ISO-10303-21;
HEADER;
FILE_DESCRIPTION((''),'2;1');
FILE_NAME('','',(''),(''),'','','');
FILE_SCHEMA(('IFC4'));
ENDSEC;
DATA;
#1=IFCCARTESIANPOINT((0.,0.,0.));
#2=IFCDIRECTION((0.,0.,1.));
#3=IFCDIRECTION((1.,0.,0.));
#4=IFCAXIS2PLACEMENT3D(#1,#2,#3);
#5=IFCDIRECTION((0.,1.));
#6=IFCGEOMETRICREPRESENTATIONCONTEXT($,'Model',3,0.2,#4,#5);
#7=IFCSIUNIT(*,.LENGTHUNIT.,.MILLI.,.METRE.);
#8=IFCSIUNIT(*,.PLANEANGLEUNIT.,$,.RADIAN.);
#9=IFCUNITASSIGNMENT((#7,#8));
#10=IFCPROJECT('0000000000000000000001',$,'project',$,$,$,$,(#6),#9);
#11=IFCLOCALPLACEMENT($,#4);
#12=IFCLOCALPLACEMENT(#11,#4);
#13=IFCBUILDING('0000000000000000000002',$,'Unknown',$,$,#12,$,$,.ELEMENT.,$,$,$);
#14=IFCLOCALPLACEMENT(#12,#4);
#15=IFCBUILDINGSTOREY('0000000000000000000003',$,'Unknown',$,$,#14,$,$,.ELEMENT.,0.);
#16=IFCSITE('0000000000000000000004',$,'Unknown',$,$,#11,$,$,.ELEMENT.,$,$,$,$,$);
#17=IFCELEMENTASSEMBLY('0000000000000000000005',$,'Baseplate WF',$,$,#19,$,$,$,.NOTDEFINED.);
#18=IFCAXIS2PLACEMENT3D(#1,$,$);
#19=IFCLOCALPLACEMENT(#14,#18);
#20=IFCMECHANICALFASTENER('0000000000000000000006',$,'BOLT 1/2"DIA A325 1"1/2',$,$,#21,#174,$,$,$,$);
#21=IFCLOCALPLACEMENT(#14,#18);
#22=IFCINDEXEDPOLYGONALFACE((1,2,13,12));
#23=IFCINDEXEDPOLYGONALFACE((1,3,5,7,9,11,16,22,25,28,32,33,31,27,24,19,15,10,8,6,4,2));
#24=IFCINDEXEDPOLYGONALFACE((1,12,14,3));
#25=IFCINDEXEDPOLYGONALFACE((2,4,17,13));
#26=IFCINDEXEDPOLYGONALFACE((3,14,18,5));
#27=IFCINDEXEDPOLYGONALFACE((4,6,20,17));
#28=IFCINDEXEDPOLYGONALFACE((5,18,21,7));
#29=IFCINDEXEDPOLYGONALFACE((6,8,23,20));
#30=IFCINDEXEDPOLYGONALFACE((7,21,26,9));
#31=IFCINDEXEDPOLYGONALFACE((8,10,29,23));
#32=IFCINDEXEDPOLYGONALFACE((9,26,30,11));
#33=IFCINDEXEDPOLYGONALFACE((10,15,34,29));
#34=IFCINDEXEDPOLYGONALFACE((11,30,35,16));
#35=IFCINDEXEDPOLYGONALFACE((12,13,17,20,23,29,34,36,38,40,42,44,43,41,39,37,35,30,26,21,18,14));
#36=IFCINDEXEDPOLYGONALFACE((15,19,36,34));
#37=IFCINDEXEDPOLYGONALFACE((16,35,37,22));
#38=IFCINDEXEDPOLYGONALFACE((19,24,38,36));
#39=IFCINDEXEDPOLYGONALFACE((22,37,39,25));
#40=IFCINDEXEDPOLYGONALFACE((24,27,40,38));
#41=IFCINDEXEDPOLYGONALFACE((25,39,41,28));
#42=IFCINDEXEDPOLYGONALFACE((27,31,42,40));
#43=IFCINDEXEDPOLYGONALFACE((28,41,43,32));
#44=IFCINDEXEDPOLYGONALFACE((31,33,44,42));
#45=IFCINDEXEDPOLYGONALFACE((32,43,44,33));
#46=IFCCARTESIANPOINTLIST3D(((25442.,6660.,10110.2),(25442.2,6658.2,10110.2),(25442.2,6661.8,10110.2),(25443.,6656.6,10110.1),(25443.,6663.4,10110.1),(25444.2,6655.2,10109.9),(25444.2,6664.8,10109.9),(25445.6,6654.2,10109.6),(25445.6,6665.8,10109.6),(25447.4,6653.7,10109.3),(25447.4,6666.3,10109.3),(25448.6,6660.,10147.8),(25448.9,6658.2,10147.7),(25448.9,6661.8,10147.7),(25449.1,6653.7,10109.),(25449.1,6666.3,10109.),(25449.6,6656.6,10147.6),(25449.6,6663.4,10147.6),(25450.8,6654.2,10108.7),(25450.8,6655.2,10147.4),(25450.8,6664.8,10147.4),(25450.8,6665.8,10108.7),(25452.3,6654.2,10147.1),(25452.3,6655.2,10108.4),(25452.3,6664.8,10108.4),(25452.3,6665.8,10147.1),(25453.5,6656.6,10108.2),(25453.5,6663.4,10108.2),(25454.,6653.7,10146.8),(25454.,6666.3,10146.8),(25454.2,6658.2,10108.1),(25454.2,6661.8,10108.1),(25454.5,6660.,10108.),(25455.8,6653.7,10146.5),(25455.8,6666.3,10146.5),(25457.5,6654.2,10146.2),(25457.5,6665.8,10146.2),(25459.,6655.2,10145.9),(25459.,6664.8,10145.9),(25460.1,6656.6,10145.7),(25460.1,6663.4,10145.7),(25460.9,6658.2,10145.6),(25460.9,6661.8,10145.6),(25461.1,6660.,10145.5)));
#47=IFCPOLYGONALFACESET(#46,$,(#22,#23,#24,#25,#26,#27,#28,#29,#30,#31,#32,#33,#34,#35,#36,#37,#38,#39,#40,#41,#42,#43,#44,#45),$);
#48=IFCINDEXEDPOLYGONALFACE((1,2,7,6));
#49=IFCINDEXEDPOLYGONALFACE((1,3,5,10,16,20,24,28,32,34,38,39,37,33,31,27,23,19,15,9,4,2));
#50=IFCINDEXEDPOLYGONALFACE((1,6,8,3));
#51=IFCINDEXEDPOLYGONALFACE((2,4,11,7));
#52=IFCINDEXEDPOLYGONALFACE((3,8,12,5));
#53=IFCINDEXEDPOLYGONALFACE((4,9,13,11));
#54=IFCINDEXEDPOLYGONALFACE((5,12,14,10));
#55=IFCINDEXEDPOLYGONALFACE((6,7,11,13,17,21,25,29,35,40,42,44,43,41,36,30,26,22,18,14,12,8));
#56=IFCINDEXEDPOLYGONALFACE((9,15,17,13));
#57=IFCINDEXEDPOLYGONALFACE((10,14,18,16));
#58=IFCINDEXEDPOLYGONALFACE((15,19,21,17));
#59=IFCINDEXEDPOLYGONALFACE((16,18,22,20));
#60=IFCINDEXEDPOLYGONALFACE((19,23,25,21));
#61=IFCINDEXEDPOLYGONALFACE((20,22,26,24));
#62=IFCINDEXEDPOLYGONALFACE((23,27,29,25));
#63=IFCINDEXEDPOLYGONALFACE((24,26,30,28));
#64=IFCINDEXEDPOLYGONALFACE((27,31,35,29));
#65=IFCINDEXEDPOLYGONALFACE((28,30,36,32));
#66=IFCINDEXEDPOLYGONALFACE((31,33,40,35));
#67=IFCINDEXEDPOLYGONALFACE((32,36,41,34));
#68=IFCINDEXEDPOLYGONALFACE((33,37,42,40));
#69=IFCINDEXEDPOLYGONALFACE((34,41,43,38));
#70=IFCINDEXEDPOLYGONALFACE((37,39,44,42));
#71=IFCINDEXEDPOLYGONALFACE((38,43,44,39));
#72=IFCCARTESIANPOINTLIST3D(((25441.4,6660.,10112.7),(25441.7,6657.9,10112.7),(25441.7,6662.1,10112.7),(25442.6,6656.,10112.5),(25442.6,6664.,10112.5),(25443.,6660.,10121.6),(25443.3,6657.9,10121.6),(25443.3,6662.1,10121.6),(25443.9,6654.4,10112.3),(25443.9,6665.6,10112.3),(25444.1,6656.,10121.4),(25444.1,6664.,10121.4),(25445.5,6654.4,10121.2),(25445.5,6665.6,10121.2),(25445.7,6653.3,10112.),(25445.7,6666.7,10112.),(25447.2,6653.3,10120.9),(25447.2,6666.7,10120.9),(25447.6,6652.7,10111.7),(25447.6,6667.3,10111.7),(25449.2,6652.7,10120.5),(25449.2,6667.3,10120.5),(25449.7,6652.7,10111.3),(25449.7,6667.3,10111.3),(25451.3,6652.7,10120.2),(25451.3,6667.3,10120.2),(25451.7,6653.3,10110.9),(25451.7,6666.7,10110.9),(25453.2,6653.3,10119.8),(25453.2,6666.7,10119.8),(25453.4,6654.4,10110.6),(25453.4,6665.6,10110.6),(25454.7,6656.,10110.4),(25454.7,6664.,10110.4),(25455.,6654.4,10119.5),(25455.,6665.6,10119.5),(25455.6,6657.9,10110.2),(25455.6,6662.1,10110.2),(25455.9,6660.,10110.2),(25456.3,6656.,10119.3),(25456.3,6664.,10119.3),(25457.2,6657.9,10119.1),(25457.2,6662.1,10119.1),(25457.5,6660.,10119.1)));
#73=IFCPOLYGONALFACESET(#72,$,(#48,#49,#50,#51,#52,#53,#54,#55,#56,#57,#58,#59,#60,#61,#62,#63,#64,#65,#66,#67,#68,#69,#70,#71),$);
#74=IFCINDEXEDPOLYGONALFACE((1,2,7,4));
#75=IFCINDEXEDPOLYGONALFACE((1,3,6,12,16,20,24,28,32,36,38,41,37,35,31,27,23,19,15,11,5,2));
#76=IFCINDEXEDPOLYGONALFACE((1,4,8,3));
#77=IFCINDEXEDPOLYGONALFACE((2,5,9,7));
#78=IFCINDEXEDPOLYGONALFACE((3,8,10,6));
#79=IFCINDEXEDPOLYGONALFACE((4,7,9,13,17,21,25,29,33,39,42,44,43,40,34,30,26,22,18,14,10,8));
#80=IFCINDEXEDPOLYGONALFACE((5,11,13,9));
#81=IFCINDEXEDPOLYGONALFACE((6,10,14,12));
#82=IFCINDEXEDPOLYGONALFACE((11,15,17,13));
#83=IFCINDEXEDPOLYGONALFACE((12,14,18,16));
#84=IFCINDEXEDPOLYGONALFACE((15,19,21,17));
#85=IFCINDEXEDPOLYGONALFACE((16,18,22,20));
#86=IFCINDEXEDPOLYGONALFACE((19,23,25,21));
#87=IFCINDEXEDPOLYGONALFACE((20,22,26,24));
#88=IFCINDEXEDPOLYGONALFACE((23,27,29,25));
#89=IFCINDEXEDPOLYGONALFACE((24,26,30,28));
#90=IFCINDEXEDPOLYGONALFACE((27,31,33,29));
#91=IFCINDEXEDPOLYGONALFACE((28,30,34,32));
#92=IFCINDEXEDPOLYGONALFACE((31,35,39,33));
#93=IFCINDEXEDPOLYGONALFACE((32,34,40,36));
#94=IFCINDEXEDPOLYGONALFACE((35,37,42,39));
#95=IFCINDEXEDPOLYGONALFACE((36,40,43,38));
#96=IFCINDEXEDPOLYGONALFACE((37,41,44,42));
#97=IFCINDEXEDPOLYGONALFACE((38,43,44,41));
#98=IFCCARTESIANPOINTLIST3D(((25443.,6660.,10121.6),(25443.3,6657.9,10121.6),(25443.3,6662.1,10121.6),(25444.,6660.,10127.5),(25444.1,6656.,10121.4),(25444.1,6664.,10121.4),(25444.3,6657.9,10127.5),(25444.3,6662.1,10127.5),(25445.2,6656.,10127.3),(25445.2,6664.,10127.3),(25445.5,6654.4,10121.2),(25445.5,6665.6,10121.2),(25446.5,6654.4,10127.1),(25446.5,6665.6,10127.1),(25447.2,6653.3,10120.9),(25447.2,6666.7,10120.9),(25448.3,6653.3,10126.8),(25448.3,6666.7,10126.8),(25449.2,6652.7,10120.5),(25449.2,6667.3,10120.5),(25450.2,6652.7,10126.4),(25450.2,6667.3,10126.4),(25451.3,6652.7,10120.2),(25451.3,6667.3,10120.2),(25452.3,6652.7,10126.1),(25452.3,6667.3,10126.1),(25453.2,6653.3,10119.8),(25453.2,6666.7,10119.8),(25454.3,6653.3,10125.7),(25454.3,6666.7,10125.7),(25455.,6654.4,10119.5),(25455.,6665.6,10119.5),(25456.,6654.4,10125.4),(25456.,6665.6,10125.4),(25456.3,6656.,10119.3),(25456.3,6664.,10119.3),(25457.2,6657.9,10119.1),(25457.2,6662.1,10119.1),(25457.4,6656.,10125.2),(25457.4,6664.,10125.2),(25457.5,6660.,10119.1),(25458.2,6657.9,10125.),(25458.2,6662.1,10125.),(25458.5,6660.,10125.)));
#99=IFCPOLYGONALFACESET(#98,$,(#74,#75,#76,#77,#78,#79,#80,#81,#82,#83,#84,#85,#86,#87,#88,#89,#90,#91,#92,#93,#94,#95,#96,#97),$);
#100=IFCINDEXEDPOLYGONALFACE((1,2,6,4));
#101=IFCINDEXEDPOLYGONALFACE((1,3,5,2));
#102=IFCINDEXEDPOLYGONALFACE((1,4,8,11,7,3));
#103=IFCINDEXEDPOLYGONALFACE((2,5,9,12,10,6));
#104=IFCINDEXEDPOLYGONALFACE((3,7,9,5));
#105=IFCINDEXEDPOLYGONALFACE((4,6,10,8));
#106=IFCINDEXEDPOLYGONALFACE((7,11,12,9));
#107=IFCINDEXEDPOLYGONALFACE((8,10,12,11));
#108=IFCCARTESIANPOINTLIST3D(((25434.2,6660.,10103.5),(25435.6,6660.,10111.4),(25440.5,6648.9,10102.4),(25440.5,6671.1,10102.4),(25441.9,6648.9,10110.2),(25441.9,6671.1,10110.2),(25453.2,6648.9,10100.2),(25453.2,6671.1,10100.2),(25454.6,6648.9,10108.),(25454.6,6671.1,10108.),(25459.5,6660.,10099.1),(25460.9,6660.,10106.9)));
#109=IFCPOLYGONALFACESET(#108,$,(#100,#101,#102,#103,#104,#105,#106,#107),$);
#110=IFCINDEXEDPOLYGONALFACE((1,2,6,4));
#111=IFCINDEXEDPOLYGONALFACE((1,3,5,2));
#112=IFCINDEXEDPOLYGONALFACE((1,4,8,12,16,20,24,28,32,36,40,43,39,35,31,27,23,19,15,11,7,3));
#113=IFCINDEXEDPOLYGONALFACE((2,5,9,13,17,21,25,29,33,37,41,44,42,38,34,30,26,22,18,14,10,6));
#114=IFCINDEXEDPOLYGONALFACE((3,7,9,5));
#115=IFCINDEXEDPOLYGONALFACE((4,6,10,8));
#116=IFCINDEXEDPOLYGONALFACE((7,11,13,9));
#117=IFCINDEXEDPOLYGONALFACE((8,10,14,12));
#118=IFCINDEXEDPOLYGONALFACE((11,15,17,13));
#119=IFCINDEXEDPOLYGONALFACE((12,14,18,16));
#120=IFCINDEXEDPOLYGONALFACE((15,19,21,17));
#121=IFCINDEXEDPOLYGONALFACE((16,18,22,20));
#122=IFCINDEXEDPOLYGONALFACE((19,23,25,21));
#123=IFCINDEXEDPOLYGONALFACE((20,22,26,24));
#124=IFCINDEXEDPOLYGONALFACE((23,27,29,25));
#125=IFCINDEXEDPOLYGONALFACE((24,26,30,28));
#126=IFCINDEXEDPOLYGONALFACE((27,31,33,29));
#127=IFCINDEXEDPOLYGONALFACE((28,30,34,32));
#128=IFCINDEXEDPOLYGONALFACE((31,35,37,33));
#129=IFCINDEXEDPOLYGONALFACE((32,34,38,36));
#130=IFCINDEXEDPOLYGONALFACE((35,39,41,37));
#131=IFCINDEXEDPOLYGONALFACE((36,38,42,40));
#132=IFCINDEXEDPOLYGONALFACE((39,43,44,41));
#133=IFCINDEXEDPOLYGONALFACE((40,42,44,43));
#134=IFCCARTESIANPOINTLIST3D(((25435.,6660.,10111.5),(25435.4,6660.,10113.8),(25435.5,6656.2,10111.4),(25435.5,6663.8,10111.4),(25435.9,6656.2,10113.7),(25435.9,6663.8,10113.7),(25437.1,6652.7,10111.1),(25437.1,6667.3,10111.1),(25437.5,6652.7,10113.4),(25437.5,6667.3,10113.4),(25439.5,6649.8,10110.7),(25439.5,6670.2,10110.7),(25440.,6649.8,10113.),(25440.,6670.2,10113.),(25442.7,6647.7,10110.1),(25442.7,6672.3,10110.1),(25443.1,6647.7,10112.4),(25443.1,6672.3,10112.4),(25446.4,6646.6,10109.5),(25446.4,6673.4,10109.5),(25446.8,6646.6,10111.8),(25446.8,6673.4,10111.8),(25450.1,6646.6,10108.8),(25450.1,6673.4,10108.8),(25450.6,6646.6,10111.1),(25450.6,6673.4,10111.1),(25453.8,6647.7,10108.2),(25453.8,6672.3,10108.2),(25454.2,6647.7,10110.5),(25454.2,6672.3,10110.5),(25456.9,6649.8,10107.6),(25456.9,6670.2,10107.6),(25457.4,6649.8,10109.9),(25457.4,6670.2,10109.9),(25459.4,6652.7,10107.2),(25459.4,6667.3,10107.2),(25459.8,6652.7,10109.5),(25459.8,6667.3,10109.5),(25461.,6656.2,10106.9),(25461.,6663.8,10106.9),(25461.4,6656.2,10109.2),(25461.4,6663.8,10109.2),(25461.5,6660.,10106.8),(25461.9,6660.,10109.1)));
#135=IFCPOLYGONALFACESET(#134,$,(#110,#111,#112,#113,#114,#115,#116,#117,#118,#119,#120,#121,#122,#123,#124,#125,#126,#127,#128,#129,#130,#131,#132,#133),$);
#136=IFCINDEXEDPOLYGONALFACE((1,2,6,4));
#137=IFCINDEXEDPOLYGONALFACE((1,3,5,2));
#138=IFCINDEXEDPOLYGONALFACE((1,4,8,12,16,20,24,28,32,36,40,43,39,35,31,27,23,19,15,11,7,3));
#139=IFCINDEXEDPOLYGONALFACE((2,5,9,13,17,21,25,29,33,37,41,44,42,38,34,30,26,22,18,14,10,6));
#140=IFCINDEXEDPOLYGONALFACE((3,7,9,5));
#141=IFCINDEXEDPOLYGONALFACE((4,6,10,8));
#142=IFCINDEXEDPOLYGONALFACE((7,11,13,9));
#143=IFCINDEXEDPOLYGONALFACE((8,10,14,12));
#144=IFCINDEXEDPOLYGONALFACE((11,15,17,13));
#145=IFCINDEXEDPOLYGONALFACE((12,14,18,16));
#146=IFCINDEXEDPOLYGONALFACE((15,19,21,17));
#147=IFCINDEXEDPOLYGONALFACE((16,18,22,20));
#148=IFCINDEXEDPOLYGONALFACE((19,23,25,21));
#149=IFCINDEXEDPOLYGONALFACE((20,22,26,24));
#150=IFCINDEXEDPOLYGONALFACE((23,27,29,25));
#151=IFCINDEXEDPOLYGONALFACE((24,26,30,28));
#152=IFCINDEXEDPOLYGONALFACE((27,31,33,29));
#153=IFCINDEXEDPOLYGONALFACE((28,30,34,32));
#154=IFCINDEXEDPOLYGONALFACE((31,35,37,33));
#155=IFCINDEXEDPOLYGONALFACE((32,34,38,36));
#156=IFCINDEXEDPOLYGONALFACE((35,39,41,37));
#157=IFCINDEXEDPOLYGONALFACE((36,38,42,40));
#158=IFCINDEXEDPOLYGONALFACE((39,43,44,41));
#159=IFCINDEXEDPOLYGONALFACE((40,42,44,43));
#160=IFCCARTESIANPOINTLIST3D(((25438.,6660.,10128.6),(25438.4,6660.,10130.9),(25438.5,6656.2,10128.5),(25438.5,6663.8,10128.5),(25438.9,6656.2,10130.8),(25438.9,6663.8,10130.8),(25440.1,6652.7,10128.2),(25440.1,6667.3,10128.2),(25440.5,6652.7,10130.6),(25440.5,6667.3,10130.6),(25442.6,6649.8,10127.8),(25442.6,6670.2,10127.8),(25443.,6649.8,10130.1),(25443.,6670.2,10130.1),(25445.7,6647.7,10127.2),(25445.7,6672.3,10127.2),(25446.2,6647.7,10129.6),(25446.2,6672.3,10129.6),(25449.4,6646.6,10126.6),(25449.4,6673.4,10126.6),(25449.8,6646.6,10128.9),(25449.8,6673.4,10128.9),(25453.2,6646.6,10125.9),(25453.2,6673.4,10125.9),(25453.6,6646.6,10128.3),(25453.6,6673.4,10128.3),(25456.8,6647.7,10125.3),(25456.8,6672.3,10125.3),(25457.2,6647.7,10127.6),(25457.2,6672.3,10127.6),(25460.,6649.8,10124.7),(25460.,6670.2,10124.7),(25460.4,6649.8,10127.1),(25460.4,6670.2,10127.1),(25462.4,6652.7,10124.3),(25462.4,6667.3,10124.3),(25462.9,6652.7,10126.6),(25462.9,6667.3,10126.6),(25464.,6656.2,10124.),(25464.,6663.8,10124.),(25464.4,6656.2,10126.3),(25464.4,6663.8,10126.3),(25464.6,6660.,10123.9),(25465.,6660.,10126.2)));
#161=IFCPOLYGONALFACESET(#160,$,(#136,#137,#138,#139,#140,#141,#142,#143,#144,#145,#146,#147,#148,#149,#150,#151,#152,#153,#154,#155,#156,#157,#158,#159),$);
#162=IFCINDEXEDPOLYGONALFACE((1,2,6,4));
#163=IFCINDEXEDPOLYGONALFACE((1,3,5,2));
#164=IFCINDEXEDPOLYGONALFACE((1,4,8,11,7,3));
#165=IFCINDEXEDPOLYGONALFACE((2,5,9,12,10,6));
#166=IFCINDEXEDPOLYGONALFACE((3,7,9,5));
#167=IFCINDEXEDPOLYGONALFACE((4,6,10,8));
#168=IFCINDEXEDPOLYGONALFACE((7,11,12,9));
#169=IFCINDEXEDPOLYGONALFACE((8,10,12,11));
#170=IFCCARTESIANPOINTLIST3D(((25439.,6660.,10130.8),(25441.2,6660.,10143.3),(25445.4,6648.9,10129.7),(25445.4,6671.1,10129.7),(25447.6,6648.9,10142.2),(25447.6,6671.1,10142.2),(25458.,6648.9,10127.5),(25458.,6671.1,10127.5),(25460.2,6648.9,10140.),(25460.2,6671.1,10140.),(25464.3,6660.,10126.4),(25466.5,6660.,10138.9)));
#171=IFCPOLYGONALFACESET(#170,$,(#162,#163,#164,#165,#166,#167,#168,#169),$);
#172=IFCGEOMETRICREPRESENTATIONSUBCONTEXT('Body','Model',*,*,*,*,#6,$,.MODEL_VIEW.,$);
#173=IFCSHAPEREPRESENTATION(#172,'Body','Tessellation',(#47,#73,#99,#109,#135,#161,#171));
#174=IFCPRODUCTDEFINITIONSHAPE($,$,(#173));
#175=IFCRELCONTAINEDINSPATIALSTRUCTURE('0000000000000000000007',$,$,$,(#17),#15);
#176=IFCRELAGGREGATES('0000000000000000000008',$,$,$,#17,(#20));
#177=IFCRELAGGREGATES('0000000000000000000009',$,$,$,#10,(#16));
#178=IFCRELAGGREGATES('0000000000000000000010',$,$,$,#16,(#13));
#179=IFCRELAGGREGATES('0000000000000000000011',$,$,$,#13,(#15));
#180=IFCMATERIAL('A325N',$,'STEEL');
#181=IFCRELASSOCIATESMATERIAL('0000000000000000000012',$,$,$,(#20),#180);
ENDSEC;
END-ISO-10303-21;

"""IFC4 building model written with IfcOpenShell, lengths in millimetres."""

from ifc_helpers import new_model, si_unit, direction, frame, origin_with_axes, place, context, subcontext, project, spatial, line, arc, indexed_curve, outline, extrude, source, transform, mapped, material, element, aggregate, save


model = new_model("IFC4")

# Units and contexts
model_context = context("Model", 3, precision=0.2, world=origin_with_axes(), true_north=direction((0.0, 1.0)))
body_context = subcontext(model_context, "Body", "Model", "MODEL_VIEW")
ifc_project = project(units=[si_unit("LENGTHUNIT", "METRE", prefix="MILLI"), si_unit("PLANEANGLEUNIT", "RADIAN")], contexts=[model_context])

# Site, building, storey
site_placement = place(None, origin_with_axes())
site = spatial("IfcSite", under=ifc_project, at=site_placement, Name="Unknown", CompositionType="ELEMENT")
building_placement = place(site_placement, origin_with_axes())
building = spatial("IfcBuilding", under=site, at=building_placement, Name="Unknown", CompositionType="ELEMENT")
storey_placement = place(building_placement, origin_with_axes())
storey = spatial("IfcBuildingStorey", under=building, at=storey_placement, Name="Unknown", CompositionType="ELEMENT", Elevation=0.0)

# Element assembly
assembly_1_placement = place(storey_placement, frame((25480.3, 6690.0, 10118.1), z_axis=(-0.173648, 0.0, -0.984808), x_axis=(0.0, -1.0, 0.0)))
assembly_1 = element("IfcElementAssembly", 1, at=assembly_1_placement, inside=storey, Name="Baseplate WF", PredefinedType="NOTDEFINED")

# Mechanical fastener
ifc_material_1 = material(Name="A325N", Category="STEEL")
shared_shape_1 = source(origin_with_axes(), body_context, "Body", "SweptSolid", [
    extrude(outline(indexed_curve([(6.3, 0.0), (0.0, 6.3), (-6.3, 0.0), (0.0, -6.3)], segments=[arc(1, 2, 3), arc(3, 4, 1)])), frame((0.0, 0.0, 17.4), z_axis=(0.0, 0.0, -1.0), x_axis=(0.0, 1.0, 0.0)), (0.0, 0.0, 1.0), 38.1),
    extrude(outline(indexed_curve([(7.3, 0.0), (0.0, 7.3), (-7.3, 0.0), (0.0, -7.3)], segments=[arc(1, 2, 3), arc(3, 4, 1)])), frame((0.0, 0.0, 15.0), z_axis=(0.0, 0.0, -1.0), x_axis=(0.0, 1.0, 0.0)), (0.0, 0.0, 1.0), 9.0),
    extrude(outline(indexed_curve([(7.3, 0.0), (0.0, 7.3), (-7.3, 0.0), (0.0, -7.3)], segments=[arc(1, 2, 3), arc(3, 4, 1)])), frame((0.0, 0.0, 6.0), z_axis=(0.0, 0.0, -1.0), x_axis=(0.0, 1.0, 0.0)), (0.0, 0.0, 1.0), 6.0),
    extrude(outline(indexed_curve([(12.8, 0.0), (6.4, 11.1), (-6.4, 11.1), (-12.8, 0.0), (-6.4, -11.1), (6.4, -11.1)], segments=[line(1, 2, 3, 4, 5, 6, 1)])), frame((0.0, 0.0, 25.3), z_axis=(0.0, 0.0, -1.0), x_axis=(0.0, 1.0, 0.0)), (0.0, 0.0, 1.0), 7.9),
    extrude(outline(indexed_curve([(13.5, 0.0), (0.0, 13.5), (-13.5, 0.0), (0.0, -13.5)], segments=[arc(1, 2, 3), arc(3, 4, 1)])), frame((0.0, 0.0, 17.4), z_axis=(0.0, 0.0, -1.0), x_axis=(0.0, 1.0, 0.0)), (0.0, 0.0, 1.0), 2.4),
    extrude(outline(indexed_curve([(13.5, 0.0), (0.0, 13.5), (-13.5, 0.0), (0.0, -13.5)], segments=[arc(1, 2, 3), arc(3, 4, 1)])), frame((0.0, 0.0, 0.0), z_axis=(0.0, 0.0, -1.0), x_axis=(0.0, 1.0, 0.0)), (0.0, 0.0, 1.0), 2.4),
    extrude(outline(indexed_curve([(12.8, 0.0), (6.4, 11.1), (-6.4, 11.1), (-12.8, 0.0), (-6.4, -11.1), (6.4, -11.1)], segments=[line(1, 2, 3, 4, 5, 6, 1)])), frame((0.0, 0.0, -2.4), z_axis=(0.0, 0.0, -1.0), x_axis=(0.0, 1.0, 0.0)), (0.0, 0.0, 1.0), 12.7),
])
mechanical_fastener_1_placement = place(assembly_1_placement, frame((30.0, 30.0, -3.0), z_axis=(0.0, 0.0, 1.0), x_axis=(-1.0, 0.0, 0.0)))
mechanical_fastener_1 = element("IfcMechanicalFastener", 2, at=mechanical_fastener_1_placement, material=ifc_material_1, Name="BOLT 1/2\"DIA A325 1\"1/2", context=body_context, shape_type="MappedRepresentation", body=[
    mapped(shared_shape_1, transform((0.0, 0.0, 0.0))),
])
aggregate(assembly_1, [mechanical_fastener_1])

save(model, "model.ifc")
